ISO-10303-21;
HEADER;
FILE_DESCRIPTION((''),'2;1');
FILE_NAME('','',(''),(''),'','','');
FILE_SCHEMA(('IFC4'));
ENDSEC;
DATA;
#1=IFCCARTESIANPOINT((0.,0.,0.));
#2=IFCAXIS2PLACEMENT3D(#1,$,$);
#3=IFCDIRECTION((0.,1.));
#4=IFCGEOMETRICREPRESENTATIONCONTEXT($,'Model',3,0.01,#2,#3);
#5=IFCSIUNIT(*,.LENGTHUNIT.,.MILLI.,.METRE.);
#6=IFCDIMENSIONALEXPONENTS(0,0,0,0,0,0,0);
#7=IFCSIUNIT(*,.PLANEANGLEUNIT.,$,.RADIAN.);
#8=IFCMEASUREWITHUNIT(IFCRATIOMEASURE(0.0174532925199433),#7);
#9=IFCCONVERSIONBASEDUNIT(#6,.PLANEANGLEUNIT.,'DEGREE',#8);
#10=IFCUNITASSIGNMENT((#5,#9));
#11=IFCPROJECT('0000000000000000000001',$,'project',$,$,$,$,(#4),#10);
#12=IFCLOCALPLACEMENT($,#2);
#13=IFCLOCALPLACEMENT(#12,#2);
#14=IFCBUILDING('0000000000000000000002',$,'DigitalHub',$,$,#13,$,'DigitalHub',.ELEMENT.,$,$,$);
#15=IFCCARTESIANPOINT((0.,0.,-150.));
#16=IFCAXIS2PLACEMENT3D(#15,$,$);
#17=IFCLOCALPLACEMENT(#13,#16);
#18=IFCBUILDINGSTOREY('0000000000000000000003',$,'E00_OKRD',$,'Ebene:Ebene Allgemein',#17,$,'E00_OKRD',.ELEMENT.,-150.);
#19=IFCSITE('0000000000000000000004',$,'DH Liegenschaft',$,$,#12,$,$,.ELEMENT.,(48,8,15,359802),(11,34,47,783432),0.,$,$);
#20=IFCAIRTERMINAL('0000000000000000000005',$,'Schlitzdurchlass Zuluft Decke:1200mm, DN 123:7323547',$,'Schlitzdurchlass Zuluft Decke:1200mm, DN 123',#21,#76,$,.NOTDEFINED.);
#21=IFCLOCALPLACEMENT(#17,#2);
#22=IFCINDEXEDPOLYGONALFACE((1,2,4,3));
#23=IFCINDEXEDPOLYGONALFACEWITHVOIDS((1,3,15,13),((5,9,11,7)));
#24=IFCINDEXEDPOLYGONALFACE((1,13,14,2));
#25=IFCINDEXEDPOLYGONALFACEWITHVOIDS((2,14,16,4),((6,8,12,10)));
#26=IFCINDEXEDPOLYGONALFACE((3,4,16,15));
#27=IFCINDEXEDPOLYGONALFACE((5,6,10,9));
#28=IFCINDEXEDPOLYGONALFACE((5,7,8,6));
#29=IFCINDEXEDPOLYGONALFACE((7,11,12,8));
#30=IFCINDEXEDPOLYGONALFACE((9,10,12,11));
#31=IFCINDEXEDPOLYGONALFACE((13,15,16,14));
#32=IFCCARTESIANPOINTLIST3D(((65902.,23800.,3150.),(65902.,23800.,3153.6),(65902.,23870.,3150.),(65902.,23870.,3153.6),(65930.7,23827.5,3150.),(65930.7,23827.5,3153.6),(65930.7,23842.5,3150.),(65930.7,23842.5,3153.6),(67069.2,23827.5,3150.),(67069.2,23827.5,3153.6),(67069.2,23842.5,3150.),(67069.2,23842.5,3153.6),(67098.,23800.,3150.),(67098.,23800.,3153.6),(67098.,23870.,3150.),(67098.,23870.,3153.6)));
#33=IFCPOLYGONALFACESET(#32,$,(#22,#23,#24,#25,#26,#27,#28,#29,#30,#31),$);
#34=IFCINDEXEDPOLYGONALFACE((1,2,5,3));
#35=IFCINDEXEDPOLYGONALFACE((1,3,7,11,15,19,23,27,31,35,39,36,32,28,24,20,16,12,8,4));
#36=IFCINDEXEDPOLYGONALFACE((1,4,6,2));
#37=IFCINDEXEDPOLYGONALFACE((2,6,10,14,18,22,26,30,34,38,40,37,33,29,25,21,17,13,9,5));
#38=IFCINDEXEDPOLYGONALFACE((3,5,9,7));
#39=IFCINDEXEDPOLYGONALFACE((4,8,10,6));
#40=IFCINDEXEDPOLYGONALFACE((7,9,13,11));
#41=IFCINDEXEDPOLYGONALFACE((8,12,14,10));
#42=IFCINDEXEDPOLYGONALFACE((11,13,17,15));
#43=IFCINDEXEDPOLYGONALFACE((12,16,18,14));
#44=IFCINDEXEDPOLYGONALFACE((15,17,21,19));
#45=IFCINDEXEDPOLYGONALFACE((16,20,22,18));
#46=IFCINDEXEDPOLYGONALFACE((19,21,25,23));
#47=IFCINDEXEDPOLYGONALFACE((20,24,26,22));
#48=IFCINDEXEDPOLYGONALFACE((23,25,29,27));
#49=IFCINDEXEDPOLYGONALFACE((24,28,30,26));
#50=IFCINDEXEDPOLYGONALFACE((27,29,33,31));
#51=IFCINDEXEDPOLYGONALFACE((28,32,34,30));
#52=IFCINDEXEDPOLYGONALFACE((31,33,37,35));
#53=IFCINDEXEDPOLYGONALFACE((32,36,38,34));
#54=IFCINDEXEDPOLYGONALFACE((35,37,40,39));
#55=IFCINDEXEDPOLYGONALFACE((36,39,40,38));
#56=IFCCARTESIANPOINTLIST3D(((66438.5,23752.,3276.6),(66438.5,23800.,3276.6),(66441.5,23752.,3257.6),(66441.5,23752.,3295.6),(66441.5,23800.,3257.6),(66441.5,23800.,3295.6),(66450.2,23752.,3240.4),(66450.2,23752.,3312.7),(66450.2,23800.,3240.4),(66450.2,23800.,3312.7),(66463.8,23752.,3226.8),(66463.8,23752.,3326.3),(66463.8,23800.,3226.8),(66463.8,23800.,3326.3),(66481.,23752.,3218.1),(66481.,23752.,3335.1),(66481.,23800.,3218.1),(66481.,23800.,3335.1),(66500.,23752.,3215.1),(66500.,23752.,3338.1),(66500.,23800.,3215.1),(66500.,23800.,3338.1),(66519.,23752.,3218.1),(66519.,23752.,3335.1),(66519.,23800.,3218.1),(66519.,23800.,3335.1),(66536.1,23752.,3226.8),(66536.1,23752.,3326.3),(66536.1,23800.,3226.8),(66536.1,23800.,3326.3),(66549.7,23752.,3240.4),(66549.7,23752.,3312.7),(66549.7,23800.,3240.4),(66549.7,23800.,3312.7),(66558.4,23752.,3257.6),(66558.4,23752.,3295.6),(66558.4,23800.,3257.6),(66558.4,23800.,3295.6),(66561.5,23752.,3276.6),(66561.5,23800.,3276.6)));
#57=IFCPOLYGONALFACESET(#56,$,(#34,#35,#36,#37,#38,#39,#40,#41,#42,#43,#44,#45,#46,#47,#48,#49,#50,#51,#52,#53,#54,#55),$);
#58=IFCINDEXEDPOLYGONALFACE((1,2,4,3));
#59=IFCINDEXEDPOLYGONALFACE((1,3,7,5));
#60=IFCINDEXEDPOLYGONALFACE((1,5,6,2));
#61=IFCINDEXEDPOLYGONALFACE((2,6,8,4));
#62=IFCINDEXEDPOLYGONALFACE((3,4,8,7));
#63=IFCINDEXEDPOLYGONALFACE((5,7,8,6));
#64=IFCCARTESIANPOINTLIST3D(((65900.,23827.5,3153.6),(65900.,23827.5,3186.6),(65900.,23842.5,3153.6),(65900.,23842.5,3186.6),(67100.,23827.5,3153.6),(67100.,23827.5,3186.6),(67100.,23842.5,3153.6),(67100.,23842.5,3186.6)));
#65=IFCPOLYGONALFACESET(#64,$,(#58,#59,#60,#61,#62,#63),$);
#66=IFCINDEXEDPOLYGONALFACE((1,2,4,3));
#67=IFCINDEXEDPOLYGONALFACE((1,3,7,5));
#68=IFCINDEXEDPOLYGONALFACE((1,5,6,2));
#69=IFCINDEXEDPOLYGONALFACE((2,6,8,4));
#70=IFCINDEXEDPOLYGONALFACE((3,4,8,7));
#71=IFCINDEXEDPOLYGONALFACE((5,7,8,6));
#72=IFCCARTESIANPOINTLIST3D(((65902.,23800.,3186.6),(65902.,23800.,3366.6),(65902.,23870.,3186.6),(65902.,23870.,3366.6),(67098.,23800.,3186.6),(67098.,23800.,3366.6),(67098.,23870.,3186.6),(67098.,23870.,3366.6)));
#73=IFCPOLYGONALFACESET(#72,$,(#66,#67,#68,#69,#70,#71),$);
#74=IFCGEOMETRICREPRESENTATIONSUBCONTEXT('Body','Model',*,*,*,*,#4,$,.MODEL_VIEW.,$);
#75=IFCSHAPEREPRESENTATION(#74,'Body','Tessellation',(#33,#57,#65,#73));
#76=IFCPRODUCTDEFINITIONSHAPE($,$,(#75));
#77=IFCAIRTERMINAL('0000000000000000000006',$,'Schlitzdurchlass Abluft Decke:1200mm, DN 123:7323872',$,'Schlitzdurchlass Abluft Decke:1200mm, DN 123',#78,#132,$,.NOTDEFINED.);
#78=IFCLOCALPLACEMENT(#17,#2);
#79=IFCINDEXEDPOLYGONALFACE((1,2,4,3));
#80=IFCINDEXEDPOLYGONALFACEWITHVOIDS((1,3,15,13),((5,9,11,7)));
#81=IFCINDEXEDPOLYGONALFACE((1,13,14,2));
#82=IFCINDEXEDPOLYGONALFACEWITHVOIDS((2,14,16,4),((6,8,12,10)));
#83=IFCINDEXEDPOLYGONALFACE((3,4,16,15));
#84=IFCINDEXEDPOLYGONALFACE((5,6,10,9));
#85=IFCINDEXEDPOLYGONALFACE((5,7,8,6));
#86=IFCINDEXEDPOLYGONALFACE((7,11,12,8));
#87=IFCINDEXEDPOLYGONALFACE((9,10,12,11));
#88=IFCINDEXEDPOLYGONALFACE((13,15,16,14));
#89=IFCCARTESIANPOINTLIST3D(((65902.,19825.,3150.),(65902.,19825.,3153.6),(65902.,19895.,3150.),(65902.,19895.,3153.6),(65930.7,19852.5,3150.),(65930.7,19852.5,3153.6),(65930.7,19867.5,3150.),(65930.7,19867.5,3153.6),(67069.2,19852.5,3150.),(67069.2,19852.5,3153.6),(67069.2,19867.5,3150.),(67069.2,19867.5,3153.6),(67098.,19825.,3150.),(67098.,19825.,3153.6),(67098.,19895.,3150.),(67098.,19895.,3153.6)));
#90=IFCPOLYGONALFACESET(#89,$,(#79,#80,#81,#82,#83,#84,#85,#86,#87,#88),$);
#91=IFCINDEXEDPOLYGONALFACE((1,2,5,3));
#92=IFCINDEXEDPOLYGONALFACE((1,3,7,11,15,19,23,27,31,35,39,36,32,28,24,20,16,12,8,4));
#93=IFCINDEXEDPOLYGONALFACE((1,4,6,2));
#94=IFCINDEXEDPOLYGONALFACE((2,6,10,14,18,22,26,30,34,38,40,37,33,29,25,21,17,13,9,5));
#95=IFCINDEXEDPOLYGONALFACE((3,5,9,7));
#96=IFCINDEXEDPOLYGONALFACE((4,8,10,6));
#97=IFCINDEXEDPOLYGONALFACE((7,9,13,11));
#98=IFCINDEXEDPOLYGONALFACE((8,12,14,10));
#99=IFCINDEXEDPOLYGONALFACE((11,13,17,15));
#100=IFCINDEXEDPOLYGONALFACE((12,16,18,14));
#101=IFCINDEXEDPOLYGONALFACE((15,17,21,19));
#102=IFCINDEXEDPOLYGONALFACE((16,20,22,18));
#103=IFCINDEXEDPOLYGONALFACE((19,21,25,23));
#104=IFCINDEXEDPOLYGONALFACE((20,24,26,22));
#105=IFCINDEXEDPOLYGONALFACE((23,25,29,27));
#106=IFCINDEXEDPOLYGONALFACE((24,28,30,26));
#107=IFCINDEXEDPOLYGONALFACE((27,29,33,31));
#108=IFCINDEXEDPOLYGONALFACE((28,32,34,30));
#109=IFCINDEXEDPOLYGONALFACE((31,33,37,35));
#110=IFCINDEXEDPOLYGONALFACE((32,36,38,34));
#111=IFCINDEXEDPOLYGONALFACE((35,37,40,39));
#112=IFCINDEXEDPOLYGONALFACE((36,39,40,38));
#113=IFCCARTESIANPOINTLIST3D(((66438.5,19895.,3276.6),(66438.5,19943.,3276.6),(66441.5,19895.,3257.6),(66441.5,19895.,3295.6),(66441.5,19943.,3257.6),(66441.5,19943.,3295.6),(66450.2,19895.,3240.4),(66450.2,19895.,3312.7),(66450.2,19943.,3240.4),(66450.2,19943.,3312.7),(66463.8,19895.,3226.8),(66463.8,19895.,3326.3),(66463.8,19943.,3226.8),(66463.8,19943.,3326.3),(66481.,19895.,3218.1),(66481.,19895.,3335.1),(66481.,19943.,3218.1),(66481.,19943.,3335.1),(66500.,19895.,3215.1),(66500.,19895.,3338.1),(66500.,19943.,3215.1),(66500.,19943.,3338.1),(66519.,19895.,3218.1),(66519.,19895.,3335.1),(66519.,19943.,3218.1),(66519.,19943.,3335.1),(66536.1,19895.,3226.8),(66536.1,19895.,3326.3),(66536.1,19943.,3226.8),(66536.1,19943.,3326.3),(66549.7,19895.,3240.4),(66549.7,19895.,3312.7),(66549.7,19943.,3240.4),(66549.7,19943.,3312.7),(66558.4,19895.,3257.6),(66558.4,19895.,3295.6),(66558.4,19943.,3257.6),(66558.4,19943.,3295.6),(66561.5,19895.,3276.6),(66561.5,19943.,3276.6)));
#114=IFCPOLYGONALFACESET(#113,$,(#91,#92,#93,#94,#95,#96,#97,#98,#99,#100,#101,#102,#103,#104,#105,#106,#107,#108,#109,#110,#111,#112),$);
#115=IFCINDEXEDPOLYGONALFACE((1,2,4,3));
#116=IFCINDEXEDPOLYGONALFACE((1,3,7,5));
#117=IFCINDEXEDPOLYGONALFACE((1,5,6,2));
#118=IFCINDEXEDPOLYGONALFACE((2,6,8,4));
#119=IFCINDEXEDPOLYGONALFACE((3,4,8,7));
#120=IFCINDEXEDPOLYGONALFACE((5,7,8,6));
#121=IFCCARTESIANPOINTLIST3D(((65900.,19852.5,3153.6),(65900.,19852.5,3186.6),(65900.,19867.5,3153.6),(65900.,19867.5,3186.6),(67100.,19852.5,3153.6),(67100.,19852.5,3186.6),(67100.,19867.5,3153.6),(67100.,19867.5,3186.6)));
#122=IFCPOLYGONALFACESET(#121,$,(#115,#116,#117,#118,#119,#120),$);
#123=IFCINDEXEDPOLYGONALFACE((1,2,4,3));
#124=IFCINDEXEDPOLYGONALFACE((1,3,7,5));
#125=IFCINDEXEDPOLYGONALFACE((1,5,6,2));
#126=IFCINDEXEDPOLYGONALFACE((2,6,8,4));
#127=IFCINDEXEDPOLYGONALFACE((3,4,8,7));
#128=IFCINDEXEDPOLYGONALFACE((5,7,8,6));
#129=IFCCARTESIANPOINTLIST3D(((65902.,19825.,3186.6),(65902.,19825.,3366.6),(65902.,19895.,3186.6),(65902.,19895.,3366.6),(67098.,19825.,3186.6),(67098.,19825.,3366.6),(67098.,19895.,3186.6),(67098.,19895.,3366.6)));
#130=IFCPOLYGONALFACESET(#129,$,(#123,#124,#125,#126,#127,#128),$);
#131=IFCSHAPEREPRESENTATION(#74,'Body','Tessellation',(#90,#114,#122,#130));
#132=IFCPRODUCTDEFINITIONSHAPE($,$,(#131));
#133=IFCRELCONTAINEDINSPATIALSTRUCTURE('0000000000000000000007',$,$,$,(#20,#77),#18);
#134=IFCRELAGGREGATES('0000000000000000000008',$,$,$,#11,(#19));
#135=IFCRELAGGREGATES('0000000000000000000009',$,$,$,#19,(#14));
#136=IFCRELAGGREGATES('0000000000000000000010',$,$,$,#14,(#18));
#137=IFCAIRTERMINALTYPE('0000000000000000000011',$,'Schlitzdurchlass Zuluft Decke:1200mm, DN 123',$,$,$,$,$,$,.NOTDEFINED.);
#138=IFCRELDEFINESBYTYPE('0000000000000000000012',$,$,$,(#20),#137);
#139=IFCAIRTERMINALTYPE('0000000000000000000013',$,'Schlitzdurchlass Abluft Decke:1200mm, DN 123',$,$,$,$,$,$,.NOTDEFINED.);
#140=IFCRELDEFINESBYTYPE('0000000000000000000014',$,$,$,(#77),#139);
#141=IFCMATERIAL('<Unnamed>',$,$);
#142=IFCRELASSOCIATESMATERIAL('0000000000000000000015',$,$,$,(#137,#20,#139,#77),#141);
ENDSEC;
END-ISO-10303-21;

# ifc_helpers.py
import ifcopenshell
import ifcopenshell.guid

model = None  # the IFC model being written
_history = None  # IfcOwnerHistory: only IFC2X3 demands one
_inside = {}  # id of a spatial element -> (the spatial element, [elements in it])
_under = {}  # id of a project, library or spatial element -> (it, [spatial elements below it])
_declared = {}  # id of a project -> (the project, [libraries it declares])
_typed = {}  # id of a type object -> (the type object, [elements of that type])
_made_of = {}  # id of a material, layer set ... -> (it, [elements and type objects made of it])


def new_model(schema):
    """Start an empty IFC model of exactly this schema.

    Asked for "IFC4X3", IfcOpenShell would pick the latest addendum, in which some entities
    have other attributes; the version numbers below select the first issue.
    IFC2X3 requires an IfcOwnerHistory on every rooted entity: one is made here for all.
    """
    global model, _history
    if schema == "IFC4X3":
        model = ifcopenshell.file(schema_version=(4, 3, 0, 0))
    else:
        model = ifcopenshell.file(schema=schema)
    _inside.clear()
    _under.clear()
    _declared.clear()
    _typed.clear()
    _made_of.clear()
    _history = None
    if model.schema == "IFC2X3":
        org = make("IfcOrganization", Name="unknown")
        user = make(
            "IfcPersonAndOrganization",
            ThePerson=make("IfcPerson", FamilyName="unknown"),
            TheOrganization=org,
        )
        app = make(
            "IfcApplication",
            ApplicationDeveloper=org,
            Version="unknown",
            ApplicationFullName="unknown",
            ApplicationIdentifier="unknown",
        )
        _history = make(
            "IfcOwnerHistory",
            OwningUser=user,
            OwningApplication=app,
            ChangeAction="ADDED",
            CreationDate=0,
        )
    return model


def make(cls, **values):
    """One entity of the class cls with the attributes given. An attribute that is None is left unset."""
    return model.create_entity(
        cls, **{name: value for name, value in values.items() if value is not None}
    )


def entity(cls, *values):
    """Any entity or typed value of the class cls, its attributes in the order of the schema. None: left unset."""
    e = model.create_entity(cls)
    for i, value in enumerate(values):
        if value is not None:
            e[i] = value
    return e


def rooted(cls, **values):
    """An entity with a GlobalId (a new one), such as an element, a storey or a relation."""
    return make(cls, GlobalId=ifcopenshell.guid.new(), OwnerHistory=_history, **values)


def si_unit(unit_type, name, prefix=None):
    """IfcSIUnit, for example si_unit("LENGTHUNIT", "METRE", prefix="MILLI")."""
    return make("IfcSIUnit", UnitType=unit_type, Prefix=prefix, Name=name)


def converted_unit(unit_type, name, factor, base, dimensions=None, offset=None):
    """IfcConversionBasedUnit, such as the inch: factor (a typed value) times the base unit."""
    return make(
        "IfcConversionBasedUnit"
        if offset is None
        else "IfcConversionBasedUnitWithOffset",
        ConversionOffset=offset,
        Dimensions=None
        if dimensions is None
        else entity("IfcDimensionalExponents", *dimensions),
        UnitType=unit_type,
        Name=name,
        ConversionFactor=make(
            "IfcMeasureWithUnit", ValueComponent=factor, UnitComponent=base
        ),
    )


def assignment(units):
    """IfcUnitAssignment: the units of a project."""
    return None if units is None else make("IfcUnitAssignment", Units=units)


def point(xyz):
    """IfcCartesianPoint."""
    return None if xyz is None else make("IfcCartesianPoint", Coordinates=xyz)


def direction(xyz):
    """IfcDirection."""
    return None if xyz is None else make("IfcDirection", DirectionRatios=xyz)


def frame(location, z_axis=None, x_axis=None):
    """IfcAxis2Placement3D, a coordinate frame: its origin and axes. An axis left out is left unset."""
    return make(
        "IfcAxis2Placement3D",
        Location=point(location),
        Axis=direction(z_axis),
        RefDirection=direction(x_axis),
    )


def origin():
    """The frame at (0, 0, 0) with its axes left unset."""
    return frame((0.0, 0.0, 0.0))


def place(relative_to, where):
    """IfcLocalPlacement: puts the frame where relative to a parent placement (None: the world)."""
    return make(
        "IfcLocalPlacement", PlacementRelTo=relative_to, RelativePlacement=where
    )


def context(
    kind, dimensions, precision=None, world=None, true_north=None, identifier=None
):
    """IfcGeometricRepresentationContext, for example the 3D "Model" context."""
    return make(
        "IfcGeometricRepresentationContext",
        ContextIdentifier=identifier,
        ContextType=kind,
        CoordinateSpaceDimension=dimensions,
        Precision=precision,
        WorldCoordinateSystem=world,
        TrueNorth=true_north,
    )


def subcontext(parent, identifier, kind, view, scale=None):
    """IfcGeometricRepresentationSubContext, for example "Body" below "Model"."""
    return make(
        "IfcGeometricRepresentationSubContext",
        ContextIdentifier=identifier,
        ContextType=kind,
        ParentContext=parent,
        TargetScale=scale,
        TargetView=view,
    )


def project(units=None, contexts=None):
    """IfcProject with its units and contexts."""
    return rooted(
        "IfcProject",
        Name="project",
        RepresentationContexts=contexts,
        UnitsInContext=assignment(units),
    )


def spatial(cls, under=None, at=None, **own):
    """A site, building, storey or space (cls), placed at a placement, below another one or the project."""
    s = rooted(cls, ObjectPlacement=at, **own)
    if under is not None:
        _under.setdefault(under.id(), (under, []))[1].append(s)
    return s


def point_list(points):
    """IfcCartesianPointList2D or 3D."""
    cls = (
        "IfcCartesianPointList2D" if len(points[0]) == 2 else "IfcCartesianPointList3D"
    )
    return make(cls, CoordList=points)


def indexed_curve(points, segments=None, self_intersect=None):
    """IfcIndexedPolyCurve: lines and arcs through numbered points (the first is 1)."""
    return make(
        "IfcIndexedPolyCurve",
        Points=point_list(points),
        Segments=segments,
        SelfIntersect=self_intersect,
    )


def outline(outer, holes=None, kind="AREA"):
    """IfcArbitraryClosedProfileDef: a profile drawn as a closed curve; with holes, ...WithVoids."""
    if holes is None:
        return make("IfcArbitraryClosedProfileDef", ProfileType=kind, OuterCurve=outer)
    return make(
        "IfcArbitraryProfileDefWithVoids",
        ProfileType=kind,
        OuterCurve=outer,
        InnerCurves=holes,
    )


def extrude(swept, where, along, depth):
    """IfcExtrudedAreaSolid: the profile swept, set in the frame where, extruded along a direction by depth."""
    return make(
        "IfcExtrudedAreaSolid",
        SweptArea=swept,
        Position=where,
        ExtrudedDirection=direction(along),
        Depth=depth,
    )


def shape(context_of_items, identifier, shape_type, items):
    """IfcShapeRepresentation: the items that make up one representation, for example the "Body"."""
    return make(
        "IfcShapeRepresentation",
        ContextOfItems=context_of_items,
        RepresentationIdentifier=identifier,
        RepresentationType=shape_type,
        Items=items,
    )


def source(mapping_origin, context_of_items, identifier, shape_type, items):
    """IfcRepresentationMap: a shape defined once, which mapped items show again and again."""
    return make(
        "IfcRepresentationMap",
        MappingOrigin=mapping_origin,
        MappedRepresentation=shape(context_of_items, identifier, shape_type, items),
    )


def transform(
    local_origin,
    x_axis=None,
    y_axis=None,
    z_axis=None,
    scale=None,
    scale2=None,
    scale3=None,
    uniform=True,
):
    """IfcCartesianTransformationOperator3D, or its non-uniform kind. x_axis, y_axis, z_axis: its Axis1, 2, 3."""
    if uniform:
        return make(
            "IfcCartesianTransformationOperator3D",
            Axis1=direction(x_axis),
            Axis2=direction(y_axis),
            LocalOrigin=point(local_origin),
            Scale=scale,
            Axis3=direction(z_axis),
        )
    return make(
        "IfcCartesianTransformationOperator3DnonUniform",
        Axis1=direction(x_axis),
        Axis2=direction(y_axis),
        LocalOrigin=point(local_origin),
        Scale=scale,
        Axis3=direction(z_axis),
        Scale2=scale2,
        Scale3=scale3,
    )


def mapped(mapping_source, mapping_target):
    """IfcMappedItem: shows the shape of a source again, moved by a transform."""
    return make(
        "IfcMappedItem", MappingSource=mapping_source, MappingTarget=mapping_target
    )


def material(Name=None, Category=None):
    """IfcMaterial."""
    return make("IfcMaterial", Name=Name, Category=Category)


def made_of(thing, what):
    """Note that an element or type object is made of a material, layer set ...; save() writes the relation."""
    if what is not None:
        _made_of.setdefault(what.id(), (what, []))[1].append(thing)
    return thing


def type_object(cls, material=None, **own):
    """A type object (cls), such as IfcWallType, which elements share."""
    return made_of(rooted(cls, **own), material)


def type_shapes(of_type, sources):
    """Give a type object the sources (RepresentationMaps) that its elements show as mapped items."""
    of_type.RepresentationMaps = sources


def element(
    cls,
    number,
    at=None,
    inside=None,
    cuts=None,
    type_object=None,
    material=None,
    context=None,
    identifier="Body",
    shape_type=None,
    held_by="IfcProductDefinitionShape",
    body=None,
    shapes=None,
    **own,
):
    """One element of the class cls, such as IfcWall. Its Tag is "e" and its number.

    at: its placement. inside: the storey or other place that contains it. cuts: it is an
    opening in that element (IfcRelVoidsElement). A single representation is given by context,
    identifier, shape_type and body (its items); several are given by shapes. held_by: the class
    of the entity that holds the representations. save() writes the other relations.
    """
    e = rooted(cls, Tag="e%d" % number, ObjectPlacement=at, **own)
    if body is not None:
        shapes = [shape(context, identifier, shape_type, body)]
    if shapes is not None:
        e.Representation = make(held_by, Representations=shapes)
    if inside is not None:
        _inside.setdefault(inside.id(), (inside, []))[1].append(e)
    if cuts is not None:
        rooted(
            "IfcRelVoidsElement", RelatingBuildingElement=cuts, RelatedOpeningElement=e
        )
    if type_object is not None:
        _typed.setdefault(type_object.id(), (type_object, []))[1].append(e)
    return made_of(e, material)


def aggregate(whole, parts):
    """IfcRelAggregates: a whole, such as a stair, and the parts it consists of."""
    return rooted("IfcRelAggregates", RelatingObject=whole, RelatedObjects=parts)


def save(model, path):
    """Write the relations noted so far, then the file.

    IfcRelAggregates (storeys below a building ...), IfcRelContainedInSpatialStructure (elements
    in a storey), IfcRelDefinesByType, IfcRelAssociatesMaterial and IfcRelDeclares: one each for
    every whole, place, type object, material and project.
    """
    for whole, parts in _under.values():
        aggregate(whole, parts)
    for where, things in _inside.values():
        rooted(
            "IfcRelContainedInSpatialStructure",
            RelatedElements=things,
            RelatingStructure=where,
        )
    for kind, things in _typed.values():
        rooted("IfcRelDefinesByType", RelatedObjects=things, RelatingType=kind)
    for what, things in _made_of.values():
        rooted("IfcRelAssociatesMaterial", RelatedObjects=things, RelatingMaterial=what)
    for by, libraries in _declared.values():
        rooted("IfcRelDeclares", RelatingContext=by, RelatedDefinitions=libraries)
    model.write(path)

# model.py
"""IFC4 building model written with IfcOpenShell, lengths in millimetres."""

from ifc_helpers import new_model, entity, si_unit, converted_unit, direction, frame, origin, place, context, subcontext, project, spatial, indexed_curve, outline, extrude, source, transform, mapped, material, type_object, type_shapes, element, save


model = new_model("IFC4")

# Units and contexts
model_context = context("Model", 3, precision=0.01, world=origin(), true_north=direction((0.0, 1.0)))
body_context = subcontext(model_context, "Body", "Model", "MODEL_VIEW")
ifc_project = project(units=[si_unit("LENGTHUNIT", "METRE", prefix="MILLI"), converted_unit("PLANEANGLEUNIT", "DEGREE", entity("IfcRatioMeasure", 0.0174532925199433), si_unit("PLANEANGLEUNIT", "RADIAN"), dimensions=[0, 0, 0, 0, 0, 0, 0])], contexts=[model_context])

# Site, building, storey
site_placement = place(None, origin())
site = spatial("IfcSite", under=ifc_project, at=site_placement, Name="DH Liegenschaft", CompositionType="ELEMENT", RefLatitude=(48, 8, 15, 359802), RefLongitude=(11, 34, 47, 783432), RefElevation=0.0)
building_placement = place(site_placement, origin())
building = spatial("IfcBuilding", under=site, at=building_placement, Name="DigitalHub", LongName="DigitalHub", CompositionType="ELEMENT")
storey_placement = place(building_placement, frame((0.0, 0.0, -150.0)))
storey = spatial("IfcBuildingStorey", under=building, at=storey_placement, Name="E00_OKRD", ObjectType="Ebene:Ebene Allgemein", LongName="E00_OKRD", CompositionType="ELEMENT", Elevation=-150.0)

# Air terminals
ifc_material_1 = material(Name="<Unnamed>")
air_terminal_type_1 = type_object("IfcAirTerminalType", Name="Schlitzdurchlass Zuluft Decke:1200mm, DN 123", PredefinedType="NOTDEFINED", material=ifc_material_1)
shared_shape_1 = source(origin(), body_context, "Body", "SweptSolid", [
    extrude(outline(indexed_curve([(-598.0, -35.0), (598.0, -35.0), (598.0, 35.0), (-598.0, 35.0), (-598.0, -35.0)], self_intersect=False), holes=[indexed_curve([(-569.2, -7.5), (-569.2, 7.5), (569.2, 7.5), (569.2, -7.5), (-569.2, -7.5)], self_intersect=False)]), frame((600.0, 35.0, 0.0), z_axis=(0.0, 0.0, 1.0), x_axis=(-1.0, 0.0, 0.0)), (0.0, 0.0, 1.0), 3.6),
    extrude(outline(indexed_curve([(61.5, 0.0), (58.5, 19.0), (49.8, 36.1), (36.1, 49.8), (19.0, 58.5), (0.0, 61.5), (-19.0, 58.5), (-36.1, 49.8), (-49.8, 36.1), (-58.5, 19.0), (-61.5, 0.0), (-58.5, -19.0), (-49.8, -36.1), (-36.1, -49.8), (-19.0, -58.5), (0.0, -61.5), (19.0, -58.5), (36.1, -49.8), (49.8, -36.1), (58.5, -19.0), (61.5, 0.0)], self_intersect=False)), frame((600.0, 70.0, 126.6), z_axis=(0.0, 1.0, 0.0), x_axis=(-1.0, 0.0, 0.0)), (0.0, 0.0, 1.0), 48.0),
    extrude(outline(indexed_curve([(-600.0, -7.5), (600.0, -7.5), (600.0, 7.5), (-600.0, 7.5), (-600.0, -7.5)], self_intersect=False)), frame((600.0, 35.0, 3.6), z_axis=(0.0, 0.0, 1.0), x_axis=(-1.0, 0.0, 0.0)), (0.0, 0.0, 1.0), 33.0),
    extrude(outline(indexed_curve([(-598.0, -35.0), (598.0, -35.0), (598.0, 35.0), (-598.0, 35.0), (-598.0, -35.0)], self_intersect=False)), frame((600.0, 35.0, 36.6), z_axis=(0.0, 0.0, 1.0), x_axis=(-1.0, 0.0, 0.0)), (0.0, 0.0, 1.0), 180.0),
])
type_shapes(air_terminal_type_1, [shared_shape_1])
air_terminal_1_placement = place(storey_placement, frame((67100.0, 23870.0, 3150.0), z_axis=(0.0, 0.0, 1.0), x_axis=(-1.0, 0.0, 0.0)))
element("IfcAirTerminal", 1, at=air_terminal_1_placement, inside=storey, type_object=air_terminal_type_1, material=ifc_material_1, Name="Schlitzdurchlass Zuluft Decke:1200mm, DN 123:7323547", ObjectType="Schlitzdurchlass Zuluft Decke:1200mm, DN 123", PredefinedType="NOTDEFINED", context=body_context, shape_type="MappedRepresentation", body=[
    mapped(shared_shape_1, transform((0.0, 0.0, 0.0), scale=1.0)),
])
air_terminal_type_2 = type_object("IfcAirTerminalType", Name="Schlitzdurchlass Abluft Decke:1200mm, DN 123", PredefinedType="NOTDEFINED", material=ifc_material_1)
shared_shape_2 = source(origin(), body_context, "Body", "SweptSolid", [
    extrude(outline(indexed_curve([(-598.0, -35.0), (598.0, -35.0), (598.0, 35.0), (-598.0, 35.0), (-598.0, -35.0)], self_intersect=False), holes=[indexed_curve([(-569.2, -7.5), (-569.2, 7.5), (569.2, 7.5), (569.2, -7.5), (-569.2, -7.5)], self_intersect=False)]), frame((0.0, 0.0, 0.0), z_axis=(0.0, 0.0, 1.0), x_axis=(-1.0, 0.0, 0.0)), (0.0, 0.0, 1.0), 3.6),
    extrude(outline(indexed_curve([(61.5, 0.0), (58.5, 19.0), (49.8, 36.1), (36.1, 49.8), (19.0, 58.5), (0.0, 61.5), (-19.0, 58.5), (-36.1, 49.8), (-49.8, 36.1), (-58.5, 19.0), (-61.5, 0.0), (-58.5, -19.0), (-49.8, -36.1), (-36.1, -49.8), (-19.0, -58.5), (0.0, -61.5), (19.0, -58.5), (36.1, -49.8), (49.8, -36.1), (58.5, -19.0), (61.5, 0.0)], self_intersect=False)), frame((0.0, 35.0, 126.6), z_axis=(0.0, 1.0, 0.0), x_axis=(-1.0, 0.0, 0.0)), (0.0, 0.0, 1.0), 48.0),
    extrude(outline(indexed_curve([(-600.0, -7.5), (600.0, -7.5), (600.0, 7.5), (-600.0, 7.5), (-600.0, -7.5)], self_intersect=False)), frame((0.0, 0.0, 3.6), z_axis=(0.0, 0.0, 1.0), x_axis=(-1.0, 0.0, 0.0)), (0.0, 0.0, 1.0), 33.0),
    extrude(outline(indexed_curve([(-598.0, -35.0), (598.0, -35.0), (598.0, 35.0), (-598.0, 35.0), (-598.0, -35.0)], self_intersect=False)), frame((0.0, 0.0, 36.6), z_axis=(0.0, 0.0, 1.0), x_axis=(-1.0, 0.0, 0.0)), (0.0, 0.0, 1.0), 180.0),
])
type_shapes(air_terminal_type_2, [shared_shape_2])
air_terminal_2_placement = place(storey_placement, frame((66500.0, 19860.0, 3150.0)))
element("IfcAirTerminal", 2, at=air_terminal_2_placement, inside=storey, type_object=air_terminal_type_2, material=ifc_material_1, Name="Schlitzdurchlass Abluft Decke:1200mm, DN 123:7323872", ObjectType="Schlitzdurchlass Abluft Decke:1200mm, DN 123", PredefinedType="NOTDEFINED", context=body_context, shape_type="MappedRepresentation", body=[
    mapped(shared_shape_2, transform((0.0, 0.0, 0.0), scale=1.0)),
])

save(model, "model.ifc")
